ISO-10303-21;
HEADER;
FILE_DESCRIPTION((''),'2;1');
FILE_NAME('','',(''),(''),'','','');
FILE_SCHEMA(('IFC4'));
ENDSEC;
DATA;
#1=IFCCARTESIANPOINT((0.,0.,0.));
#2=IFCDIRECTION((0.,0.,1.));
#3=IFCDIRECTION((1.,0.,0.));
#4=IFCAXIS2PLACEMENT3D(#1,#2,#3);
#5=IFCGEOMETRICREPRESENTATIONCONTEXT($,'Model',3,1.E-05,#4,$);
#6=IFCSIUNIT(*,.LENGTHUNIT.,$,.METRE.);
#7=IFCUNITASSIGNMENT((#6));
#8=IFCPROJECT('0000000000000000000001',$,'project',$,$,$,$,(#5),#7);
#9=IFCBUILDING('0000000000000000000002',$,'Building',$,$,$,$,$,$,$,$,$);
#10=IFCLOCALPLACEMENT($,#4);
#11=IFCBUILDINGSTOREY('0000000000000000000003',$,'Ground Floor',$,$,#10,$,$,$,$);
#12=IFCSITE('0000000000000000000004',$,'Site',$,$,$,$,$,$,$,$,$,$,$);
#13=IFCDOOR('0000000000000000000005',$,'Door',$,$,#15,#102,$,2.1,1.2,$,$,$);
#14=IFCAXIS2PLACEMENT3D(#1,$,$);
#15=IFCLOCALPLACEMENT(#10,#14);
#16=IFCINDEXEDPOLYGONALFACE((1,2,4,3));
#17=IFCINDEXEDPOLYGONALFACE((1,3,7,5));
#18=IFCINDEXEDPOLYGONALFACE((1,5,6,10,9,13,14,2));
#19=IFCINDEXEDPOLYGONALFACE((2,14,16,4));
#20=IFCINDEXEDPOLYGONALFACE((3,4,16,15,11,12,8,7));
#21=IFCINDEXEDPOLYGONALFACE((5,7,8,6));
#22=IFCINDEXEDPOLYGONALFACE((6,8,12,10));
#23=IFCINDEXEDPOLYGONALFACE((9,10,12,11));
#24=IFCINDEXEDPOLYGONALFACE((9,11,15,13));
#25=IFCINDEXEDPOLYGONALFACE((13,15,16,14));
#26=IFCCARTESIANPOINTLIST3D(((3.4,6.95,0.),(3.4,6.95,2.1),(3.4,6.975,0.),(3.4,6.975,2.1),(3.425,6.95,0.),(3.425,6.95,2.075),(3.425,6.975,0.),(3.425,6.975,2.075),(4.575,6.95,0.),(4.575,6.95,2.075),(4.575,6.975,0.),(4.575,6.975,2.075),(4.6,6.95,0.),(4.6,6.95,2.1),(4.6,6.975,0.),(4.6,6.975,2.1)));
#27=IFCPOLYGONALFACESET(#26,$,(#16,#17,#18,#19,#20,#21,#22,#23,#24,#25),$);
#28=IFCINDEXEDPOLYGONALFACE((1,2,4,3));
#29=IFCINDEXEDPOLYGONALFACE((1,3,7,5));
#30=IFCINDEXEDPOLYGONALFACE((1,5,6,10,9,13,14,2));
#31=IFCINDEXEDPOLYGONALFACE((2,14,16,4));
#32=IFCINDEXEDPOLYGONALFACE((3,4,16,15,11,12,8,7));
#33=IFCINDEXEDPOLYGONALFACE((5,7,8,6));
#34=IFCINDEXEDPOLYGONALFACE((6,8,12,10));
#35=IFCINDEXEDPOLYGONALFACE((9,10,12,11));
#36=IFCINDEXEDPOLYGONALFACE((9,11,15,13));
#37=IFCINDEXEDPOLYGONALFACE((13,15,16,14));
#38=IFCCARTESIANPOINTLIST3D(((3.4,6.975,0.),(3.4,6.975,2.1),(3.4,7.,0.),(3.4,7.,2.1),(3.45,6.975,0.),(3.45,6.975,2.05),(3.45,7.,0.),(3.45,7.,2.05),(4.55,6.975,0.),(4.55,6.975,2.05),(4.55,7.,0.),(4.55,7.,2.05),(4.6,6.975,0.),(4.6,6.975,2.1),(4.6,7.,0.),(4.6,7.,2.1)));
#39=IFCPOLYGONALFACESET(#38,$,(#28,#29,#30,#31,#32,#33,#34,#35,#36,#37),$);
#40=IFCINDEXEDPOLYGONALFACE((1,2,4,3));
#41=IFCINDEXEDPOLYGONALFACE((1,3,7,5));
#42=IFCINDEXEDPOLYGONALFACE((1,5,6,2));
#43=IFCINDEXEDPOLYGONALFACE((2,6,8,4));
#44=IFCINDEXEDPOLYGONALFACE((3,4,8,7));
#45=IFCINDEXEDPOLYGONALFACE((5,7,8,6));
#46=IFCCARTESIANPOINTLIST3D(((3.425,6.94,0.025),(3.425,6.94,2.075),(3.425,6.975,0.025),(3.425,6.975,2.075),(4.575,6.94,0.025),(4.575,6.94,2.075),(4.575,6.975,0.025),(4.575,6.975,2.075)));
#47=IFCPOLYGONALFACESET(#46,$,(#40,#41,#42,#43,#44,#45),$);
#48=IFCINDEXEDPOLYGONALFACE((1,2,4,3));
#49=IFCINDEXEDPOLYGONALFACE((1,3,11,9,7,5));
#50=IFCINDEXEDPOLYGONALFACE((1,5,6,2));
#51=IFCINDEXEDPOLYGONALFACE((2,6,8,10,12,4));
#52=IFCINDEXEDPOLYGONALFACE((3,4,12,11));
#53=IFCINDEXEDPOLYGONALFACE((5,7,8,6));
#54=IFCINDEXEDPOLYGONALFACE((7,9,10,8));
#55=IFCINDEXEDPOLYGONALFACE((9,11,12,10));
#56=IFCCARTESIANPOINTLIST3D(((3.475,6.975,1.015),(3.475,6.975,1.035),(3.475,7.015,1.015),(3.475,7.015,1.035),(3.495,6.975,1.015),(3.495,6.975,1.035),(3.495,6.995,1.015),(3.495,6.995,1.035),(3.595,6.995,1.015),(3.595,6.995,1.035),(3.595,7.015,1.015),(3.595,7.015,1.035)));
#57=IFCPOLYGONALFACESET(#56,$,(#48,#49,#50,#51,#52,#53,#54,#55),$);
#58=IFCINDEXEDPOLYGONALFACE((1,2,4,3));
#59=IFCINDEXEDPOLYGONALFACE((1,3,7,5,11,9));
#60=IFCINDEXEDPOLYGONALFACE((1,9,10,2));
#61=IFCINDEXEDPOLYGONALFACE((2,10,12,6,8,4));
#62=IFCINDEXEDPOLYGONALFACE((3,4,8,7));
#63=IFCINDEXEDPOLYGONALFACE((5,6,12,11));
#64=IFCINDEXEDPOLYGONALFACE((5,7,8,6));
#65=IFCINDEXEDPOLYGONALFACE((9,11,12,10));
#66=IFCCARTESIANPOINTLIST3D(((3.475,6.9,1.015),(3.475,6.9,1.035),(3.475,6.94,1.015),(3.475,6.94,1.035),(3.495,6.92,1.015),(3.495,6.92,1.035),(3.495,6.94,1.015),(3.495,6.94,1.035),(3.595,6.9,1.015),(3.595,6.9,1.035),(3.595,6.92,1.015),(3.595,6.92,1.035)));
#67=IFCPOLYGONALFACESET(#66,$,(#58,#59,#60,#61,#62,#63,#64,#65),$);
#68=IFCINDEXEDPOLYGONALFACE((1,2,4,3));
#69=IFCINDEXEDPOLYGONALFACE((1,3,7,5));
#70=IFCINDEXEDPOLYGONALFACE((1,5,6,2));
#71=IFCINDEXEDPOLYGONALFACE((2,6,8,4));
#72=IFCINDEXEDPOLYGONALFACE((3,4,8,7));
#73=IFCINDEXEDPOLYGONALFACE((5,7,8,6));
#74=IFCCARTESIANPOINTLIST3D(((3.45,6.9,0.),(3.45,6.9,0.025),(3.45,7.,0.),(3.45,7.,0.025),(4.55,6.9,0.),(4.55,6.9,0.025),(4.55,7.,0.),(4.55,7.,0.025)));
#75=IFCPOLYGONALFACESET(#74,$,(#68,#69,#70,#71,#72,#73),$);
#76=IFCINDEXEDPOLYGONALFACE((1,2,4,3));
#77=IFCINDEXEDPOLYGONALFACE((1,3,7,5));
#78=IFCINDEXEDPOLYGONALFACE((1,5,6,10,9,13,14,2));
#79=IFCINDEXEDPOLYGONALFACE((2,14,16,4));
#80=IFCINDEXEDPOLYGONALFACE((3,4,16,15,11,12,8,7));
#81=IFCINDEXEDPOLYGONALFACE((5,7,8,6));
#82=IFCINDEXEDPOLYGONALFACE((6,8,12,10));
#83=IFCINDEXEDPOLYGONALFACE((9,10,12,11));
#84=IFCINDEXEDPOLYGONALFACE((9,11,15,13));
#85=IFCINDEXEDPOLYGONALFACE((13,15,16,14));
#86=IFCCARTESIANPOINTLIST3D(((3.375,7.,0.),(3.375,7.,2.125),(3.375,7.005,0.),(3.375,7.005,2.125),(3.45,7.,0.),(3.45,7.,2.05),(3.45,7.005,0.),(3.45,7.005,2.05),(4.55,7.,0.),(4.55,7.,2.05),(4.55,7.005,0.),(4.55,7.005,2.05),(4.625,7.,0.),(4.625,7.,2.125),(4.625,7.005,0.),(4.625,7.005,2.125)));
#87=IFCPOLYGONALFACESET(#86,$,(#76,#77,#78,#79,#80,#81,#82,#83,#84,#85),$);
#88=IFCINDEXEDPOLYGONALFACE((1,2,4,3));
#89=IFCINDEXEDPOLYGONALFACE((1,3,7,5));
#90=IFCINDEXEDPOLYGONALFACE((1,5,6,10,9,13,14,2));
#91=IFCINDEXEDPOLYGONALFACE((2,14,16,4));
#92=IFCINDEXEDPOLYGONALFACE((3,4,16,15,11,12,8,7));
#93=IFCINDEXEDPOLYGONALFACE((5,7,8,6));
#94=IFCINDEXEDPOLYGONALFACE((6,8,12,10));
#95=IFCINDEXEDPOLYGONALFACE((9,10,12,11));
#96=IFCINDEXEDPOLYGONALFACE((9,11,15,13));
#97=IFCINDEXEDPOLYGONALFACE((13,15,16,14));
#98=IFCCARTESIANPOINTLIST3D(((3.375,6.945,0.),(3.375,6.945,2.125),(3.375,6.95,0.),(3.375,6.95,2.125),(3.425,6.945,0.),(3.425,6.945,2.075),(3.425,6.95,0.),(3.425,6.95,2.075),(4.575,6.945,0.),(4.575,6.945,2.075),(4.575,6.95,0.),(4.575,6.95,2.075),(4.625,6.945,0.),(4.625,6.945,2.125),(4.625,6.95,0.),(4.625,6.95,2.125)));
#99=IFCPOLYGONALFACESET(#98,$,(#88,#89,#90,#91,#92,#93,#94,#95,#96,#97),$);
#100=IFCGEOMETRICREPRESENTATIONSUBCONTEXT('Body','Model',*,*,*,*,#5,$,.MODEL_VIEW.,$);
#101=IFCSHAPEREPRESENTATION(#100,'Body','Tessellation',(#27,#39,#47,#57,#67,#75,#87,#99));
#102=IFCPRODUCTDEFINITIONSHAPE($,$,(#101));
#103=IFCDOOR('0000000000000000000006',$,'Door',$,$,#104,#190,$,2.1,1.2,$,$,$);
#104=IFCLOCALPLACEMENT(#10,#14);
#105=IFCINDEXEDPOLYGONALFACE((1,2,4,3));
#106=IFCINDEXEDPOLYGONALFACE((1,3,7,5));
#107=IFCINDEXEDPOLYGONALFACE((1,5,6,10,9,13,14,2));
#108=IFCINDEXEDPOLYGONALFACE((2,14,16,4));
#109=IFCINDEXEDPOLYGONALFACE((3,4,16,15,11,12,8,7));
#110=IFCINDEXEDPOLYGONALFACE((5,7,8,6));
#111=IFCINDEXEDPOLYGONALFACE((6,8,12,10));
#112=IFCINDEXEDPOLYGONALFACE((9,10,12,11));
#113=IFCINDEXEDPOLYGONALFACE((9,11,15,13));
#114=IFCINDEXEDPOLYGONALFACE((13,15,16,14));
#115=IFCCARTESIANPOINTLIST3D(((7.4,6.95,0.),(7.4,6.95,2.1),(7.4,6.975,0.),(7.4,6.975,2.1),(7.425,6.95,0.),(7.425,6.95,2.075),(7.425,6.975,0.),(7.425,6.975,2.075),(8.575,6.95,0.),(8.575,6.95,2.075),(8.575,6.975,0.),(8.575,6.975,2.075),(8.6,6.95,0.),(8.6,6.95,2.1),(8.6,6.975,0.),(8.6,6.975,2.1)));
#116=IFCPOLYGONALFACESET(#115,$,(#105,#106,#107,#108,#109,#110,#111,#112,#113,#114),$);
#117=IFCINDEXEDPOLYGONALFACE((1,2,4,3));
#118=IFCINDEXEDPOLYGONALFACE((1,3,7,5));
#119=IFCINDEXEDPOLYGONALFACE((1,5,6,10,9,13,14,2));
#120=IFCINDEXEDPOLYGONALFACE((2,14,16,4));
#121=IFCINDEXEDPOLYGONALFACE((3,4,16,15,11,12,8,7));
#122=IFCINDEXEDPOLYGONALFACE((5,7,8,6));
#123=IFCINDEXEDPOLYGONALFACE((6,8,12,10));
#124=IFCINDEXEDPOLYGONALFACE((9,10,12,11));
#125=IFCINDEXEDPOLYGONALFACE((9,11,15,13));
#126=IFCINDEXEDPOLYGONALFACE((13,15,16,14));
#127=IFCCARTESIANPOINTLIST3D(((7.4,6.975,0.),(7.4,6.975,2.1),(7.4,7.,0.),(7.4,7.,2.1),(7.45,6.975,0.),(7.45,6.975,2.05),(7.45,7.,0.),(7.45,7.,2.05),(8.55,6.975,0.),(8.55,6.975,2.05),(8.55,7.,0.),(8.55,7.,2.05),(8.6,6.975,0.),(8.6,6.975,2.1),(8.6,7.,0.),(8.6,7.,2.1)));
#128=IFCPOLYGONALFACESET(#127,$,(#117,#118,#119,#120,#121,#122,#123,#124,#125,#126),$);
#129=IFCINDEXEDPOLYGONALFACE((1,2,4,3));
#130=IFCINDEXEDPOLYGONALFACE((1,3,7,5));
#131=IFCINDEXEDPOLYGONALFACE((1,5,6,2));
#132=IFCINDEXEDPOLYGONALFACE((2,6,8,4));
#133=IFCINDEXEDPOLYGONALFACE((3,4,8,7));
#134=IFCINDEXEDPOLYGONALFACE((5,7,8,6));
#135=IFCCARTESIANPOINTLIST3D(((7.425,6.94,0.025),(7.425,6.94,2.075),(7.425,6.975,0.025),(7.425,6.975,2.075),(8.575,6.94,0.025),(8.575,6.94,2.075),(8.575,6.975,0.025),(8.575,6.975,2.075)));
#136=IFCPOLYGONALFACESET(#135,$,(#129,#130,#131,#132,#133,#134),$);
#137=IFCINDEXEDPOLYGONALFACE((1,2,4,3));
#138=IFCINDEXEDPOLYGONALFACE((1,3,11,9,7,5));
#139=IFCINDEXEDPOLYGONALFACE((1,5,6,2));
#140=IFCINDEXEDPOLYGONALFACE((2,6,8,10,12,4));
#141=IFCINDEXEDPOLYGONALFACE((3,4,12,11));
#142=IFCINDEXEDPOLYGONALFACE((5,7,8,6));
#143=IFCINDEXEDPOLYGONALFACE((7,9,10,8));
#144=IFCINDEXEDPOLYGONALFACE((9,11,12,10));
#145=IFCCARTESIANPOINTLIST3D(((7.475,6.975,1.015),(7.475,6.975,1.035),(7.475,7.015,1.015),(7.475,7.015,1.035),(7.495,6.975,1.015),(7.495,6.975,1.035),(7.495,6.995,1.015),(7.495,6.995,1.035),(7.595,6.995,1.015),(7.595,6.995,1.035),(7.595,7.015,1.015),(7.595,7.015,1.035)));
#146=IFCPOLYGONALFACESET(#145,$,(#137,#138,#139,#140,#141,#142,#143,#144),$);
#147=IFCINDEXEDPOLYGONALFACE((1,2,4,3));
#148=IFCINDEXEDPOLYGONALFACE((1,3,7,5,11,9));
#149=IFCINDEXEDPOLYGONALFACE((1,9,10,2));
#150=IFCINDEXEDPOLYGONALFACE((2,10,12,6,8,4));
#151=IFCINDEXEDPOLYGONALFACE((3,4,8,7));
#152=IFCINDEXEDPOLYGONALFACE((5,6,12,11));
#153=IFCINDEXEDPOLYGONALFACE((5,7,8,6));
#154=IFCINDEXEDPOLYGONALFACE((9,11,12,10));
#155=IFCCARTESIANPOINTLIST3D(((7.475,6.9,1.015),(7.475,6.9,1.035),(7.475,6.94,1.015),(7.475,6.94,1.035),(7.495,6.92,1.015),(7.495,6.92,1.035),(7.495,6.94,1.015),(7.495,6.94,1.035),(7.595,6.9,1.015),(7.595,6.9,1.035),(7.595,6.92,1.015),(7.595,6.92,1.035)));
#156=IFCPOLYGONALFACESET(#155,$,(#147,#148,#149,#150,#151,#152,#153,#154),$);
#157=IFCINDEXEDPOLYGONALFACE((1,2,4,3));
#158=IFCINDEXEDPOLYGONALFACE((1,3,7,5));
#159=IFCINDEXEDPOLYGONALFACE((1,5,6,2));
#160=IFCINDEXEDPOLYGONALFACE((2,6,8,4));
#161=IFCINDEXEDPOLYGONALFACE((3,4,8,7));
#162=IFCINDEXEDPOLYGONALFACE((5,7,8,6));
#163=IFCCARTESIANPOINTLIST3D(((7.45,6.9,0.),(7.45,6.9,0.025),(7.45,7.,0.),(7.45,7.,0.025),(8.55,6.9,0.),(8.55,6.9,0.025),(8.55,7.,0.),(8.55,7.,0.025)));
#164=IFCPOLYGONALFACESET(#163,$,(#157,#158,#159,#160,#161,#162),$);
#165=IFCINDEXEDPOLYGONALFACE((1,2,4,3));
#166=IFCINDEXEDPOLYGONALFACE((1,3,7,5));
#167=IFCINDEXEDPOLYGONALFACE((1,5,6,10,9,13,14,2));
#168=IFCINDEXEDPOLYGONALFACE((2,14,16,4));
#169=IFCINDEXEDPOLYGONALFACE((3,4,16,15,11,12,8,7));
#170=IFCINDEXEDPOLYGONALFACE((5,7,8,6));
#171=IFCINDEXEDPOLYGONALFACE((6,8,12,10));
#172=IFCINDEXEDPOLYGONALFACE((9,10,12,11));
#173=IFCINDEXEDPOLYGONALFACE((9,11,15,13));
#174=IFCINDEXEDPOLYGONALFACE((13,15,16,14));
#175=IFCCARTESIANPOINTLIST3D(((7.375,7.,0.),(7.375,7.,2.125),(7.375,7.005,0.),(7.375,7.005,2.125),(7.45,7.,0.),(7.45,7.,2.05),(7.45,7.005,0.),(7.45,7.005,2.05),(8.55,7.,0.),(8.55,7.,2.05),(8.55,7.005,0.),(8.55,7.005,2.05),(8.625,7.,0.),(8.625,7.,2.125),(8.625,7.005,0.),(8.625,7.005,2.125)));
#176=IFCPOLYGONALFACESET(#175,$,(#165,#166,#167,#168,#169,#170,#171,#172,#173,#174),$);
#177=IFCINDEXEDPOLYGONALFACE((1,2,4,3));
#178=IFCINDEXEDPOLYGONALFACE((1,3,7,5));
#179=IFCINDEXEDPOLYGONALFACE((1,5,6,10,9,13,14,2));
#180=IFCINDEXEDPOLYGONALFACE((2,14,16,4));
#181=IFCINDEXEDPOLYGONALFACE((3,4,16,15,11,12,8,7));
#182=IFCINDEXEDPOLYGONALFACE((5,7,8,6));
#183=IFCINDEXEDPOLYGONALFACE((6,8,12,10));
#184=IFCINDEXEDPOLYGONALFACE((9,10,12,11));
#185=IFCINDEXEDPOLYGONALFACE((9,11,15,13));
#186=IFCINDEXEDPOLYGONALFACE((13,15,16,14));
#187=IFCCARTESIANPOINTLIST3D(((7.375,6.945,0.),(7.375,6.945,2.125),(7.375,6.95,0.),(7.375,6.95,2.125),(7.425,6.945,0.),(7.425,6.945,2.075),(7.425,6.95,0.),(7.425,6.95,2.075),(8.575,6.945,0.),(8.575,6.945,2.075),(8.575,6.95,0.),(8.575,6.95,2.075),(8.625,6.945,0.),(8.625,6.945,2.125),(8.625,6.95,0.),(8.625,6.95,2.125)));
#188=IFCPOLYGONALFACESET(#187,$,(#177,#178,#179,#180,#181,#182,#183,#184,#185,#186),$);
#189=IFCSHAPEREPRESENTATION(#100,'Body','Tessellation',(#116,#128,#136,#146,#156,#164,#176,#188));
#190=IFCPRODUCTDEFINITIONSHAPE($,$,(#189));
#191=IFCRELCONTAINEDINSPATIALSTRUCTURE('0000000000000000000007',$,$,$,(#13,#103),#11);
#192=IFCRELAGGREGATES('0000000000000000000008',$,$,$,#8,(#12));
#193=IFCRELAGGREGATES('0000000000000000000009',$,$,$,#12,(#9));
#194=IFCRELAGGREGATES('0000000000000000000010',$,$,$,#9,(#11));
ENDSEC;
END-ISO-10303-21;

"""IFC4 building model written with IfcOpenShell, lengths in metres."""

from ifc_helpers import new_model, si_unit, frame, origin_with_axes, place, context, subcontext, project, spatial, line, indexed_curve, outline, extrude, element, save


model = new_model("IFC4")

# Units and contexts
model_context = context("Model", 3, precision=1e-05, world=origin_with_axes())
body_context = subcontext(model_context, "Body", "Model", "MODEL_VIEW")
ifc_project = project(units=[si_unit("LENGTHUNIT", "METRE")], contexts=[model_context])

# Site, building, storey
site = spatial("IfcSite", under=ifc_project, Name="Site")
building = spatial("IfcBuilding", under=site, Name="Building")
storey_placement = place(None, origin_with_axes())
storey = spatial("IfcBuildingStorey", under=building, at=storey_placement, Name="Ground Floor")

# Doors
door_1_placement = place(storey_placement, frame((4.6, 7.0, 0.0), z_axis=(0.0, 0.0, 1.0), x_axis=(-1.0, 0.0, 0.0)))
element("IfcDoor", 1, at=door_1_placement, inside=storey, Name="Door", OverallHeight=2.1, OverallWidth=1.2, context=body_context, shape_type="SweptSolid", body=[
    extrude(outline(indexed_curve([(0.0, 0.0), (0.0, 2.1), (1.2, 2.1), (1.2, 0.0), (1.175, 0.0), (1.175, 2.075), (0.025, 2.075), (0.025, 0.0)], segments=[line(1, 2, 3, 4, 5, 6, 7, 8, 1)])), frame((0.0, 0.025, 0.0), z_axis=(0.0, -1.0, 0.0), x_axis=(1.0, 0.0, 0.0)), (0.0, 0.0, -1.0), 0.025),
    extrude(outline(indexed_curve([(0.0, 0.0), (0.0, 2.1), (1.2, 2.1), (1.2, 0.0), (1.15, 0.0), (1.15, 2.05), (0.05, 2.05), (0.05, 0.0)], segments=[line(1, 2, 3, 4, 5, 6, 7, 8, 1)])), frame((0.0, 0.0, 0.0), z_axis=(0.0, -1.0, 0.0), x_axis=(1.0, 0.0, 0.0)), (0.0, 0.0, -1.0), 0.025),
    extrude(outline(indexed_curve([(0.0, 0.0), (1.15, 0.0), (1.15, 0.035), (0.0, 0.035)], segments=[line(1, 2, 3, 4, 1)])), frame((0.025, 0.025, 0.025), z_axis=(0.0, 0.0, 1.0), x_axis=(1.0, 0.0, 0.0)), (0.0, 0.0, 1.0), 2.05),
    extrude(outline(indexed_curve([(0.0, 0.0), (0.0, -0.04), (-0.12, -0.04), (-0.12, -0.02), (-0.02, -0.02), (-0.02, 0.0)], segments=[line(1, 2, 3, 4, 5, 6, 1)])), frame((1.125, 0.025, 1.015), z_axis=(0.0, 0.0, 1.0), x_axis=(1.0, 0.0, 0.0)), (0.0, 0.0, 1.0), 0.02),
    extrude(outline(indexed_curve([(0.0, 0.0), (0.0, 0.04), (-0.12, 0.04), (-0.12, 0.02), (-0.02, 0.02), (-0.02, 0.0)], segments=[line(1, 2, 3, 4, 5, 6, 1)])), frame((1.125, 0.06, 1.015), z_axis=(0.0, 0.0, 1.0), x_axis=(1.0, 0.0, 0.0)), (0.0, 0.0, 1.0), 0.02),
    extrude(outline(indexed_curve([(0.0, 0.0), (1.1, 0.0), (1.1, 0.1), (0.0, 0.1)], segments=[line(1, 2, 3, 4, 1)])), frame((0.05, 0.0, 0.0), z_axis=(0.0, 0.0, 1.0), x_axis=(1.0, 0.0, 0.0)), (0.0, 0.0, 1.0), 0.025),
    extrude(outline(indexed_curve([(0.0, 0.0), (0.0, 2.125), (1.25, 2.125), (1.25, 0.0), (1.175, 0.0), (1.175, 2.05), (0.075, 2.05), (0.075, 0.0)], segments=[line(1, 2, 3, 4, 5, 6, 7, 8, 1)])), frame((-0.025, -0.005, 0.0), z_axis=(0.0, -1.0, 0.0), x_axis=(1.0, 0.0, 0.0)), (0.0, 0.0, -1.0), 0.005),
    extrude(outline(indexed_curve([(0.0, 0.0), (0.0, 2.125), (1.25, 2.125), (1.25, 0.0), (1.2, 0.0), (1.2, 2.075), (0.05, 2.075), (0.05, 0.0)], segments=[line(1, 2, 3, 4, 5, 6, 7, 8, 1)])), frame((-0.025, 0.05, 0.0), z_axis=(0.0, -1.0, 0.0), x_axis=(1.0, 0.0, 0.0)), (0.0, 0.0, -1.0), 0.005),
])
door_2_placement = place(storey_placement, frame((8.6, 7.0, 0.0), z_axis=(0.0, 0.0, 1.0), x_axis=(-1.0, 0.0, 0.0)))
element("IfcDoor", 2, at=door_2_placement, inside=storey, Name="Door", OverallHeight=2.1, OverallWidth=1.2, context=body_context, shape_type="SweptSolid", body=[
    extrude(outline(indexed_curve([(0.0, 0.0), (0.0, 2.1), (1.2, 2.1), (1.2, 0.0), (1.175, 0.0), (1.175, 2.075), (0.025, 2.075), (0.025, 0.0)], segments=[line(1, 2, 3, 4, 5, 6, 7, 8, 1)])), frame((0.0, 0.025, 0.0), z_axis=(0.0, -1.0, 0.0), x_axis=(1.0, 0.0, 0.0)), (0.0, 0.0, -1.0), 0.025),
    extrude(outline(indexed_curve([(0.0, 0.0), (0.0, 2.1), (1.2, 2.1), (1.2, 0.0), (1.15, 0.0), (1.15, 2.05), (0.05, 2.05), (0.05, 0.0)], segments=[line(1, 2, 3, 4, 5, 6, 7, 8, 1)])), frame((0.0, 0.0, 0.0), z_axis=(0.0, -1.0, 0.0), x_axis=(1.0, 0.0, 0.0)), (0.0, 0.0, -1.0), 0.025),
    extrude(outline(indexed_curve([(0.0, 0.0), (1.15, 0.0), (1.15, 0.035), (0.0, 0.035)], segments=[line(1, 2, 3, 4, 1)])), frame((0.025, 0.025, 0.025), z_axis=(0.0, 0.0, 1.0), x_axis=(1.0, 0.0, 0.0)), (0.0, 0.0, 1.0), 2.05),
    extrude(outline(indexed_curve([(0.0, 0.0), (0.0, -0.04), (-0.12, -0.04), (-0.12, -0.02), (-0.02, -0.02), (-0.02, 0.0)], segments=[line(1, 2, 3, 4, 5, 6, 1)])), frame((1.125, 0.025, 1.015), z_axis=(0.0, 0.0, 1.0), x_axis=(1.0, 0.0, 0.0)), (0.0, 0.0, 1.0), 0.02),
    extrude(outline(indexed_curve([(0.0, 0.0), (0.0, 0.04), (-0.12, 0.04), (-0.12, 0.02), (-0.02, 0.02), (-0.02, 0.0)], segments=[line(1, 2, 3, 4, 5, 6, 1)])), frame((1.125, 0.06, 1.015), z_axis=(0.0, 0.0, 1.0), x_axis=(1.0, 0.0, 0.0)), (0.0, 0.0, 1.0), 0.02),
    extrude(outline(indexed_curve([(0.0, 0.0), (1.1, 0.0), (1.1, 0.1), (0.0, 0.1)], segments=[line(1, 2, 3, 4, 1)])), frame((0.05, 0.0, 0.0), z_axis=(0.0, 0.0, 1.0), x_axis=(1.0, 0.0, 0.0)), (0.0, 0.0, 1.0), 0.025),
    extrude(outline(indexed_curve([(0.0, 0.0), (0.0, 2.125), (1.25, 2.125), (1.25, 0.0), (1.175, 0.0), (1.175, 2.05), (0.075, 2.05), (0.075, 0.0)], segments=[line(1, 2, 3, 4, 5, 6, 7, 8, 1)])), frame((-0.025, -0.005, 0.0), z_axis=(0.0, -1.0, 0.0), x_axis=(1.0, 0.0, 0.0)), (0.0, 0.0, -1.0), 0.005),
    extrude(outline(indexed_curve([(0.0, 0.0), (0.0, 2.125), (1.25, 2.125), (1.25, 0.0), (1.2, 0.0), (1.2, 2.075), (0.05, 2.075), (0.05, 0.0)], segments=[line(1, 2, 3, 4, 5, 6, 7, 8, 1)])), frame((-0.025, 0.05, 0.0), z_axis=(0.0, -1.0, 0.0), x_axis=(1.0, 0.0, 0.0)), (0.0, 0.0, -1.0), 0.005),
])

save(model, "model.ifc")
